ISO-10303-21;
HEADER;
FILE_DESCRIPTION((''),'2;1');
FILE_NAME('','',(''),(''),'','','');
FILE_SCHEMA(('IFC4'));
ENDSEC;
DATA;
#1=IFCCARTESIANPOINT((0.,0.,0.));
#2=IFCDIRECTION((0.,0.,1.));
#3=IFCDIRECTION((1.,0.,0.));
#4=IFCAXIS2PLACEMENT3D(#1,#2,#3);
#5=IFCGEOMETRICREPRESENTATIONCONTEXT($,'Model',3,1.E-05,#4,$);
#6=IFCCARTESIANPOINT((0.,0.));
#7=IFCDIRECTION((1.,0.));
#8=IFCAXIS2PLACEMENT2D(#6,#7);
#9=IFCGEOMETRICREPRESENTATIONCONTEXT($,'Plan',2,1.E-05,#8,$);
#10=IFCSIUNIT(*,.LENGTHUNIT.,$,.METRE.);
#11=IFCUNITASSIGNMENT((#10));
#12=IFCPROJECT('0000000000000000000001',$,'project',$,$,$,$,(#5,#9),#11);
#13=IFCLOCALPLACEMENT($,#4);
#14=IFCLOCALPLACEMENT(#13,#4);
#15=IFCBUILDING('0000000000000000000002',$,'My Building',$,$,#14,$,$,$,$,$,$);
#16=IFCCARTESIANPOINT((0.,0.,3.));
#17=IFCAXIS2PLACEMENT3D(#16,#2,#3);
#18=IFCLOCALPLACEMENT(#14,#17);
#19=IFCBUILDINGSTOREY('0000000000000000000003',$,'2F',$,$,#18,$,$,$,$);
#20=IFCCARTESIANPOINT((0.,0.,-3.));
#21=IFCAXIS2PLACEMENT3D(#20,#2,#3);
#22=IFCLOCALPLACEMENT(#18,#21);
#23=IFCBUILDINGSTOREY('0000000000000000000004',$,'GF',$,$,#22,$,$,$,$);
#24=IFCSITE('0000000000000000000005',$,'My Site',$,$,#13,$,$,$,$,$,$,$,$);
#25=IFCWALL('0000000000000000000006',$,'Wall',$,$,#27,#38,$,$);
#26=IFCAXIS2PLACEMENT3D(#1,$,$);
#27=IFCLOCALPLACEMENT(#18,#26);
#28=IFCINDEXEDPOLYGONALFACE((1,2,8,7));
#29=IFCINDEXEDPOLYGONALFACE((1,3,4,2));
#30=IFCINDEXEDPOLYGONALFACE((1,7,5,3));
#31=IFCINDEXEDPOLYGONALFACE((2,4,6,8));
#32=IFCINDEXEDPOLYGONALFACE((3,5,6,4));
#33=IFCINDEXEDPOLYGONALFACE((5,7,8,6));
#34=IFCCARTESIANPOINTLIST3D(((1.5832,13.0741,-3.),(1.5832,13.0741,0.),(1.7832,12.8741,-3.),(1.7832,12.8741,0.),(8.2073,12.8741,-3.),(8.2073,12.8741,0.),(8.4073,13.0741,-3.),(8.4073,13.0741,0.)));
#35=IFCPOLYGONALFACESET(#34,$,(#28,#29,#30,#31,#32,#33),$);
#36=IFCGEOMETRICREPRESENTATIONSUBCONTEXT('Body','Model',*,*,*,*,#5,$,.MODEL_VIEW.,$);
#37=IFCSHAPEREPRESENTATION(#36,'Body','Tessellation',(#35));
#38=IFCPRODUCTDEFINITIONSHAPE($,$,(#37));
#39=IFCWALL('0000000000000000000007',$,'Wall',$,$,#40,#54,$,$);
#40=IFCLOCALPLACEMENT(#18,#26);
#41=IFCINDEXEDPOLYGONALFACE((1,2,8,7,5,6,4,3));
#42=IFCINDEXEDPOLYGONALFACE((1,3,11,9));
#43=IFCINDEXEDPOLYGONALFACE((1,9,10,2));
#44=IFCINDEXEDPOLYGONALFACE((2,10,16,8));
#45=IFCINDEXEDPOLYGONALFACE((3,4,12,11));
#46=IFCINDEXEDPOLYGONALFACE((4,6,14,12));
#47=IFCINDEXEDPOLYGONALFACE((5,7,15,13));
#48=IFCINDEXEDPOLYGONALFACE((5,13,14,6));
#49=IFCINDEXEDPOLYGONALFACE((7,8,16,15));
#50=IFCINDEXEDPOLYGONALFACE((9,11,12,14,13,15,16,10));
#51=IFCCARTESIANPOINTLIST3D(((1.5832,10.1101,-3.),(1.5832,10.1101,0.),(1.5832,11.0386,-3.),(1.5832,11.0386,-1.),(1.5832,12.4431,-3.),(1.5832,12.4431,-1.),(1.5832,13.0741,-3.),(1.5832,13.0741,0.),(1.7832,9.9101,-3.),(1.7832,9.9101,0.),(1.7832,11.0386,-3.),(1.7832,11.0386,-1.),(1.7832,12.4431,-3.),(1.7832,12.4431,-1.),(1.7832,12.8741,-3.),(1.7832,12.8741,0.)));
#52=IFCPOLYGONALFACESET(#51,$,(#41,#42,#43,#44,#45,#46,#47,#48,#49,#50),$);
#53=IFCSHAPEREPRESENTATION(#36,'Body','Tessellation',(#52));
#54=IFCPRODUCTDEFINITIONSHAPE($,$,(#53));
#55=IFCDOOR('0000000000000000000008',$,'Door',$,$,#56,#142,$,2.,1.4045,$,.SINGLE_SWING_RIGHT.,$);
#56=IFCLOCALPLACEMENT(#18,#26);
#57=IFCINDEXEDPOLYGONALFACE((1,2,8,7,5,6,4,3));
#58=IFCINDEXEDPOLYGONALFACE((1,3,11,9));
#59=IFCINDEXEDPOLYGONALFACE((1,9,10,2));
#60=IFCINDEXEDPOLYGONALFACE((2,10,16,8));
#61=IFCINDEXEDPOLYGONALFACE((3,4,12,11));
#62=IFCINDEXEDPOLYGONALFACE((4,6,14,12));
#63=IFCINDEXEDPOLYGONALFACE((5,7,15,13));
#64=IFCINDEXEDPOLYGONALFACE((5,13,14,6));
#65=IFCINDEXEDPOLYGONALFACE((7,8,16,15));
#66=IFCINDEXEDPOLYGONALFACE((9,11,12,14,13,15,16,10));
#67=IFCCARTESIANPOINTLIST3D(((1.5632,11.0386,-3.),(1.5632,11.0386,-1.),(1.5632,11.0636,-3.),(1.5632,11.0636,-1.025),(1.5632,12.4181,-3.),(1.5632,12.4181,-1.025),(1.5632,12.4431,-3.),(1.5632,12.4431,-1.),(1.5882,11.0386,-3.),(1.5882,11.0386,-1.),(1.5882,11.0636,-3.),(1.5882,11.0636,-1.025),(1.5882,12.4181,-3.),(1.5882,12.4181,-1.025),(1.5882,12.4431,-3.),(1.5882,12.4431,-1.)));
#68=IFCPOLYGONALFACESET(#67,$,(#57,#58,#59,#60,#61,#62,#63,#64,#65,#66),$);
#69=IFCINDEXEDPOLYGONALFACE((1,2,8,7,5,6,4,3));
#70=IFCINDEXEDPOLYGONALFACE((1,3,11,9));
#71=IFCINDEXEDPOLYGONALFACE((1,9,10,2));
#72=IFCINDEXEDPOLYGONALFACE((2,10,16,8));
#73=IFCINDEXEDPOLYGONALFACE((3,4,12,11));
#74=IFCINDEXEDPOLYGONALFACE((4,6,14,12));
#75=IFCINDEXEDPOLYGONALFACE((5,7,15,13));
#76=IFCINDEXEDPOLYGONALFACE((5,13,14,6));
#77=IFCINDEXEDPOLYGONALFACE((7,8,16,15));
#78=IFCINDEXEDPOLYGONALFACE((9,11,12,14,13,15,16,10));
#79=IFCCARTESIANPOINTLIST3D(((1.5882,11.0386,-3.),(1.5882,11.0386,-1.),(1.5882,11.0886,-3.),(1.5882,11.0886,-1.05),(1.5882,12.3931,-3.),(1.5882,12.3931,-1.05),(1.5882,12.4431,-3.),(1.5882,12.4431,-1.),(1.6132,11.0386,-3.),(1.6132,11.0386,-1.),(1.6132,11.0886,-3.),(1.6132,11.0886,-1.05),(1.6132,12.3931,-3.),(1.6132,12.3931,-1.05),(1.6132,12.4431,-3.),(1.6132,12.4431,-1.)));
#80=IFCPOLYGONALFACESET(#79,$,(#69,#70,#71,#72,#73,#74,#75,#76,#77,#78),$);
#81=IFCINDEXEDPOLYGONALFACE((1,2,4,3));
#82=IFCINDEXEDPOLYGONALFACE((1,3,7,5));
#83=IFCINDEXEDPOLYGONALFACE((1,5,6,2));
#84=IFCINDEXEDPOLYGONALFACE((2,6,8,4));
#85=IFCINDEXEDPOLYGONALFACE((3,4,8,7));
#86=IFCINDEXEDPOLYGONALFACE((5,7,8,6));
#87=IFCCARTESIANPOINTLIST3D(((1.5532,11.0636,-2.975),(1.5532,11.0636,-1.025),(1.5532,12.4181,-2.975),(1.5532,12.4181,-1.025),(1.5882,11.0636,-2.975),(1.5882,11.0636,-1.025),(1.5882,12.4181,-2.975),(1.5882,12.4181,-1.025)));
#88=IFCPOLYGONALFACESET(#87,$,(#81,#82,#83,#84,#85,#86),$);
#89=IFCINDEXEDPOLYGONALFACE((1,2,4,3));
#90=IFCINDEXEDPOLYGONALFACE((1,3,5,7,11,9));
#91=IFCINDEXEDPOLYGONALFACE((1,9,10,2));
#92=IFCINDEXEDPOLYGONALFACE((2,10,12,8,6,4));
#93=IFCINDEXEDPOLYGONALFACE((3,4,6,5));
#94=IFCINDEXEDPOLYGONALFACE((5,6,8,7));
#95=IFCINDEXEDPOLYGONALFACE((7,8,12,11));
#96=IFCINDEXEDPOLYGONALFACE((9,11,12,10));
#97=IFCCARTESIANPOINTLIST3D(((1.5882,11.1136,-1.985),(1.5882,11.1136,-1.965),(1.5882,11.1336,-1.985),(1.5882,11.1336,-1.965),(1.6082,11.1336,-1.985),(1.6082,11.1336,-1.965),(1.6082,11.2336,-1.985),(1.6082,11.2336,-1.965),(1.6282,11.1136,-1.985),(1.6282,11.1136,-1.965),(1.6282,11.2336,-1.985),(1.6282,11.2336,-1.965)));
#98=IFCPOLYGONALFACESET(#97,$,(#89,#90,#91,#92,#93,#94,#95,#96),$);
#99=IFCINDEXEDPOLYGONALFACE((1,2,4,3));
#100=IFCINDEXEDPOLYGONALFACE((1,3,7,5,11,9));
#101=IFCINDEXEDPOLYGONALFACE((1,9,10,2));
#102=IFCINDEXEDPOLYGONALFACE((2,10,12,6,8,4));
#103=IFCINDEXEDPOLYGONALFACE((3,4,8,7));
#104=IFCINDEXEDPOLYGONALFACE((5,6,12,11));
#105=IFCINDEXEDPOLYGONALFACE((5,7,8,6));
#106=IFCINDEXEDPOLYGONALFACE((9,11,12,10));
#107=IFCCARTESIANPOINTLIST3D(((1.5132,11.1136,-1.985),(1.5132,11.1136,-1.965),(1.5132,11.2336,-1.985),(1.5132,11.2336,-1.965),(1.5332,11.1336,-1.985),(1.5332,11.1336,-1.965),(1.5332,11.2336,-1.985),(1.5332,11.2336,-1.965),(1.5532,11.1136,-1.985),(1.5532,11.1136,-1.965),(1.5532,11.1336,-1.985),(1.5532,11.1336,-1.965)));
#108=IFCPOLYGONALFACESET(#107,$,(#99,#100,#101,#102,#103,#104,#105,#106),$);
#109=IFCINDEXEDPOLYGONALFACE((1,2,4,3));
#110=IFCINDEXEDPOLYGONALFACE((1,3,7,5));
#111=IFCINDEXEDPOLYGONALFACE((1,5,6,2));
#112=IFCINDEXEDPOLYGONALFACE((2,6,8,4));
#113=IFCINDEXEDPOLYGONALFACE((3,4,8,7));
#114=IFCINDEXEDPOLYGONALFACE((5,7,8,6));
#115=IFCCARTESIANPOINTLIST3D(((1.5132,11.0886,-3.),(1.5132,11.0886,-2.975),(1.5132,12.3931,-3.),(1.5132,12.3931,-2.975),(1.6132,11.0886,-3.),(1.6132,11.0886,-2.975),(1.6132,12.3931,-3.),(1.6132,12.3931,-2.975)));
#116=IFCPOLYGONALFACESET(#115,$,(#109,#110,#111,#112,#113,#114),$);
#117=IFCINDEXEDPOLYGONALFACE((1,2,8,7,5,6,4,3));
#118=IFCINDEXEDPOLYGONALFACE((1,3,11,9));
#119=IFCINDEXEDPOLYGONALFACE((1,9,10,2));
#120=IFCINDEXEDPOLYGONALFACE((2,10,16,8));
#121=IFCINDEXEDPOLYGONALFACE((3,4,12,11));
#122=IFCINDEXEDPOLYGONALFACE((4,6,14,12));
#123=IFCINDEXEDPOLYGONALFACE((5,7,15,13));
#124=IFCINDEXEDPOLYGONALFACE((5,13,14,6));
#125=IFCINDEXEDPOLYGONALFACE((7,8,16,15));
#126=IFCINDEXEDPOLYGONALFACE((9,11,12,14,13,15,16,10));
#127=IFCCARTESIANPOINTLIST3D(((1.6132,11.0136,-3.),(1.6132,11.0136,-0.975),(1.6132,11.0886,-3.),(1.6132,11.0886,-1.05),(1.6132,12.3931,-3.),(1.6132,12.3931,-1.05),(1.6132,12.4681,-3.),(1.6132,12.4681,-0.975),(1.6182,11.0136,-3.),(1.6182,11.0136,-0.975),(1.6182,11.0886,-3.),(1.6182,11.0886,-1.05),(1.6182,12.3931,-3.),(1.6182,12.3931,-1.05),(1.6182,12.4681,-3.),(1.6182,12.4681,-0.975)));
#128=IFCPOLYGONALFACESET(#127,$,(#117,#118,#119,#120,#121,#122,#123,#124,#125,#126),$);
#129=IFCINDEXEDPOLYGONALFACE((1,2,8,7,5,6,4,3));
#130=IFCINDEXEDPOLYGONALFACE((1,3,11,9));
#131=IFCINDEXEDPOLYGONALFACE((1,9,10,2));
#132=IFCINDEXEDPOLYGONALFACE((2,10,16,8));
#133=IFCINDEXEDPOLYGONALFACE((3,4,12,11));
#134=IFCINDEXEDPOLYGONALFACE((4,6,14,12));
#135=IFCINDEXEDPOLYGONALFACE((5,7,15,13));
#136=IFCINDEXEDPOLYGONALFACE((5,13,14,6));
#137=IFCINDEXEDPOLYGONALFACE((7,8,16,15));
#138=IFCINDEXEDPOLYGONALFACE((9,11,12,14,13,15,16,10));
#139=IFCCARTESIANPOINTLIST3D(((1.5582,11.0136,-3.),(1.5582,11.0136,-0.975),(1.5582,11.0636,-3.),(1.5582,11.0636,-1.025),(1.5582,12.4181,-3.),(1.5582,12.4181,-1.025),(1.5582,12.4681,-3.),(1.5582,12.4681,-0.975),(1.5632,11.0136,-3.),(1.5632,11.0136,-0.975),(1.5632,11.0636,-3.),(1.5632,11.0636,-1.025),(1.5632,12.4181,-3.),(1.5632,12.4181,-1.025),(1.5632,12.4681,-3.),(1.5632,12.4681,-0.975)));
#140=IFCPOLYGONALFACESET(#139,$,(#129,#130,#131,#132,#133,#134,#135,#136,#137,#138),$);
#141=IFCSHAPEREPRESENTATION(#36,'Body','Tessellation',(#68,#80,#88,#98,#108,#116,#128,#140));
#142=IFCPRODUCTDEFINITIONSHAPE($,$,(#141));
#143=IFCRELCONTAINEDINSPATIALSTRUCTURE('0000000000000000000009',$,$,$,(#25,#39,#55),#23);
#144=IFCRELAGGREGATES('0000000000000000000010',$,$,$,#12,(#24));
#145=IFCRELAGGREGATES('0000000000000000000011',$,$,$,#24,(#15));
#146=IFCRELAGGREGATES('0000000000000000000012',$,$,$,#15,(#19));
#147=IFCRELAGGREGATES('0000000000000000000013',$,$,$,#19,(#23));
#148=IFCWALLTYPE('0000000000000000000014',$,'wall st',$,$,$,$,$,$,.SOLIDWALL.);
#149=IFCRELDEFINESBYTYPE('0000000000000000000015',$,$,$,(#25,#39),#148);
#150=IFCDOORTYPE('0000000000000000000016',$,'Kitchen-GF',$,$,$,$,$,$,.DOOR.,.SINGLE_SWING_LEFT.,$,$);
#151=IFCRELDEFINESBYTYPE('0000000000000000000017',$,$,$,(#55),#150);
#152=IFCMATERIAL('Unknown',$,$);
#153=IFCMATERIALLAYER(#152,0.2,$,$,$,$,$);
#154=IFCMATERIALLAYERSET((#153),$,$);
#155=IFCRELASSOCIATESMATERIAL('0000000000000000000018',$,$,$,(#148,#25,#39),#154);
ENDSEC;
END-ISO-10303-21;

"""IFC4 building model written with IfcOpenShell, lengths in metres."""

from ifc_helpers import new_model, entity, si_unit, frame, origin_with_axes, origin_2d_with_axis, place, context, subcontext, project, spatial, line, indexed_curve, outline, extrude, shape, source, transform, mapped, material, layer, layer_set, layer_usage, type_object, type_shapes, element, fill, save


model = new_model("IFC4")

# Units and contexts
model_context = context("Model", 3, precision=1e-05, world=origin_with_axes())
plan_context = context("Plan", 2, precision=1e-05, world=origin_2d_with_axis())
body_context_1 = subcontext(model_context, "Body", "Model", "MODEL_VIEW")
body_context_2 = subcontext(plan_context, "Body", "Plan", "PLAN_VIEW")
ifc_project = project(units=[si_unit("LENGTHUNIT", "METRE")], contexts=[model_context, plan_context])

# Site, building, storeys
site_placement = place(None, origin_with_axes())
site = spatial("IfcSite", under=ifc_project, at=site_placement, Name="My Site")
building_placement = place(site_placement, origin_with_axes())
building = spatial("IfcBuilding", under=site, at=building_placement, Name="My Building")
storey_1_placement = place(building_placement, frame((0.0, 0.0, 3.0), z_axis=(0.0, 0.0, 1.0), x_axis=(1.0, 0.0, 0.0)))
storey_1 = spatial("IfcBuildingStorey", under=building, at=storey_1_placement, Name="2F")
storey_2_placement = place(storey_1_placement, frame((0.0, 0.0, -3.0), z_axis=(0.0, 0.0, 1.0), x_axis=(1.0, 0.0, 0.0)))
storey_2 = spatial("IfcBuildingStorey", under=storey_1, at=storey_2_placement, Name="GF")

# Shared definitions
ifc_material = material(Name="Unknown")

# Wall
ifc_layer = layer(ifc_material, 0.2)
ifc_layer_set = layer_set([ifc_layer])
ifc_layer_usage_1 = layer_usage(ifc_layer_set, "AXIS2", "POSITIVE", 0.0)
wall_type = type_object("IfcWallType", Name="wall st", PredefinedType="SOLIDWALL", material=ifc_layer_set)
wall_1_placement = place(storey_2_placement, frame((8.4073, 13.0741, 0.0), z_axis=(0.0, 0.0, 1.0), x_axis=(-1.0, 0.0, 0.0)))
element("IfcWall", 1, at=wall_1_placement, inside=storey_2, type_object=wall_type, material=ifc_layer_usage_1, Name="Wall", context=body_context_1, shape_type="SweptSolid", body=[
    extrude(outline(indexed_curve([(0.0, 0.0), (0.2, 0.2), (6.6241, 0.2), (6.8241, 0.0)], segments=[line(1, 2, 3, 4, 1)])), origin_with_axes(), (0.0, 0.0, 1.0), 3.0),
])

# Wall, opening, door
ifc_layer_usage_2 = layer_usage(ifc_layer_set, "AXIS2", "POSITIVE", 0.0)
wall_2_placement = place(storey_2_placement, frame((1.5832, 13.0741, 0.0), z_axis=(0.0, 0.0, 1.0), x_axis=(0.0, -1.0, 0.0)))
wall_2 = element("IfcWall", 2, at=wall_2_placement, inside=storey_2, type_object=wall_type, material=ifc_layer_usage_2, Name="Wall", context=body_context_1, shape_type="SweptSolid", body=[
    extrude(outline(indexed_curve([(0.0, 0.0), (0.2, 0.2), (3.164, 0.2), (2.964, 0.0)], segments=[line(1, 2, 3, 4, 1)])), origin_with_axes(), (0.0, 0.0, 1.0), 3.0),
])
shared_shape_1 = source(origin_with_axes(), body_context_1, "Body", "SweptSolid", [
    extrude(outline(indexed_curve([(0.0, 0.0), (1.4045, 0.0), (1.4045, 2.0), (0.0, 2.0)], segments=[line(1, 2, 3, 4, 1)])), frame((0.0, -0.6, 0.0), z_axis=(0.0, -1.0, 0.0), x_axis=(1.0, 0.0, 0.0)), (0.0, 0.0, -1.0), 1.2),
])
opening_1_placement = place(wall_2_placement, frame((2.0355, 0.03, 0.0), z_axis=(0.0, 0.0, 1.0), x_axis=(-1.0, 0.0, 0.0)))
opening_1 = element("IfcOpeningElement", 3, at=opening_1_placement, cuts=wall_2, PredefinedType="OPENING", context=body_context_1, shape_type="MappedRepresentation", body=[
    mapped(shared_shape_1, transform((0.0, 0.0, 0.0), x_axis=(1.0, 0.0, 0.0), y_axis=(0.0, 1.0, 0.0), z_axis=(0.0, 0.0, 1.0), scale=1.0)),
])
door_type_1 = type_object("IfcDoorType", Name="Kitchen-GF", OperationType="SINGLE_SWING_LEFT", PredefinedType="DOOR")
shared_shape_2 = source(origin_with_axes(), body_context_1, "Body", "SweptSolid", [
    extrude(outline(indexed_curve([(0.0, 0.0), (0.0, 2.0), (1.4045, 2.0), (1.4045, 0.0), (1.3795, 0.0), (1.3795, 1.975), (0.025, 1.975), (0.025, 0.0)], segments=[line(1, 2, 3, 4, 5, 6, 7, 8, 1)])), frame((0.0, 0.025, 0.0), z_axis=(0.0, -1.0, 0.0), x_axis=(1.0, 0.0, 0.0)), (0.0, 0.0, -1.0), 0.025),
    extrude(outline(indexed_curve([(0.0, 0.0), (0.0, 2.0), (1.4045, 2.0), (1.4045, 0.0), (1.3545, 0.0), (1.3545, 1.95), (0.05, 1.95), (0.05, 0.0)], segments=[line(1, 2, 3, 4, 5, 6, 7, 8, 1)])), frame((0.0, 0.0, 0.0), z_axis=(0.0, -1.0, 0.0), x_axis=(1.0, 0.0, 0.0)), (0.0, 0.0, -1.0), 0.025),
    extrude(outline(indexed_curve([(0.0, 0.0), (1.3545, 0.0), (1.3545, 0.035), (0.0, 0.035)], segments=[line(1, 2, 3, 4, 1)])), frame((0.025, 0.025, 0.025), z_axis=(0.0, 0.0, 1.0), x_axis=(1.0, 0.0, 0.0)), (0.0, 0.0, 1.0), 1.95),
    extrude(outline(indexed_curve([(0.0, 0.0), (0.0, -0.04), (0.12, -0.04), (0.12, -0.02), (0.02, -0.02), (0.02, 0.0)], segments=[line(1, 2, 3, 4, 5, 6, 1)])), frame((0.075, 0.025, 1.015), z_axis=(0.0, 0.0, 1.0), x_axis=(1.0, 0.0, 0.0)), (0.0, 0.0, 1.0), 0.02),
    extrude(outline(indexed_curve([(0.0, 0.0), (0.0, 0.04), (0.12, 0.04), (0.12, 0.02), (0.02, 0.02), (0.02, 0.0)], segments=[line(1, 2, 3, 4, 5, 6, 1)])), frame((0.075, 0.06, 1.015), z_axis=(0.0, 0.0, 1.0), x_axis=(1.0, 0.0, 0.0)), (0.0, 0.0, 1.0), 0.02),
    extrude(outline(indexed_curve([(0.0, 0.0), (1.3045, 0.0), (1.3045, 0.1), (0.0, 0.1)], segments=[line(1, 2, 3, 4, 1)])), frame((0.05, 0.0, 0.0), z_axis=(0.0, 0.0, 1.0), x_axis=(1.0, 0.0, 0.0)), (0.0, 0.0, 1.0), 0.025),
    extrude(outline(indexed_curve([(0.0, 0.0), (0.0, 2.025), (1.4545, 2.025), (1.4545, 0.0), (1.3795, 0.0), (1.3795, 1.95), (0.075, 1.95), (0.075, 0.0)], segments=[line(1, 2, 3, 4, 5, 6, 7, 8, 1)])), frame((-0.025, -0.005, 0.0), z_axis=(0.0, -1.0, 0.0), x_axis=(1.0, 0.0, 0.0)), (0.0, 0.0, -1.0), 0.005),
    extrude(outline(indexed_curve([(0.0, 0.0), (0.0, 2.025), (1.4545, 2.025), (1.4545, 0.0), (1.4045, 0.0), (1.4045, 1.975), (0.05, 1.975), (0.05, 0.0)], segments=[line(1, 2, 3, 4, 5, 6, 7, 8, 1)])), frame((-0.025, 0.05, 0.0), z_axis=(0.0, -1.0, 0.0), x_axis=(1.0, 0.0, 0.0)), (0.0, 0.0, -1.0), 0.005),
])
shared_shape_3 = source(origin_with_axes(), body_context_2, "Body", "Curve2D", [
    entity("IfcIndexedPolyCurve", entity("IfcCartesianPointList2D", [[0.0, 0.0], [0.0, 0.05], [0.025, 0.05], [0.025, 0.025], [0.05, 0.025], [0.05, 0.0]]), [entity("IfcLineIndex", [1, 2, 3, 4, 5, 6, 1])]),
    entity("IfcIndexedPolyCurve", entity("IfcCartesianPointList2D", [[1.4045, 0.0], [1.4045, 0.05], [1.3795, 0.05], [1.3795, 0.025], [1.3545, 0.025], [1.3545, 0.0]]), [entity("IfcLineIndex", [1, 2, 3, 4, 5, 6, 1])]),
    entity("IfcTrimmedCurve", entity("IfcEllipse", entity("IfcAxis2Placement2D", entity("IfcCartesianPoint", [1.3445, 0.05]), entity("IfcDirection", [1.0, 0.0])), 1.3195, 1.3545), [entity("IfcCartesianPoint", [1.3445, 1.4045])], [entity("IfcCartesianPoint", [0.025, 0.05])], True, "CARTESIAN"),
    entity("IfcIndexedPolyCurve", entity("IfcCartesianPointList2D", [[1.3795, 0.05], [1.3445, 0.05], [1.3445, 1.4045], [1.3795, 1.4045]]), [entity("IfcLineIndex", [1, 2, 3, 4, 1])]),
])
type_shapes(door_type_1, [shared_shape_2, shared_shape_3])
door_1_placement = place(opening_1_placement, frame((0.0, 0.0, 0.0), z_axis=(0.0, 0.0, 1.0), x_axis=(1.0, 0.0, 0.0)))
door_1 = element("IfcDoor", 4, at=door_1_placement, inside=storey_2, type_object=door_type_1, Name="Door", OperationType="SINGLE_SWING_RIGHT", OverallHeight=2.0, OverallWidth=1.4045, shapes=[
    shape(body_context_1, "Body", "MappedRepresentation", [mapped(shared_shape_2, transform((0.0, 0.0, 0.0), x_axis=(1.0, 0.0, 0.0), y_axis=(0.0, 1.0, 0.0), z_axis=(0.0, 0.0, 1.0), scale=1.0))]),
    shape(body_context_2, "Body", "MappedRepresentation", [mapped(shared_shape_3, transform((0.0, 0.0, 0.0), x_axis=(1.0, 0.0, 0.0), y_axis=(0.0, 1.0, 0.0), z_axis=(0.0, 0.0, 1.0), scale=1.0))]),
])
fill(opening_1, door_1)

save(model, "model.ifc")
